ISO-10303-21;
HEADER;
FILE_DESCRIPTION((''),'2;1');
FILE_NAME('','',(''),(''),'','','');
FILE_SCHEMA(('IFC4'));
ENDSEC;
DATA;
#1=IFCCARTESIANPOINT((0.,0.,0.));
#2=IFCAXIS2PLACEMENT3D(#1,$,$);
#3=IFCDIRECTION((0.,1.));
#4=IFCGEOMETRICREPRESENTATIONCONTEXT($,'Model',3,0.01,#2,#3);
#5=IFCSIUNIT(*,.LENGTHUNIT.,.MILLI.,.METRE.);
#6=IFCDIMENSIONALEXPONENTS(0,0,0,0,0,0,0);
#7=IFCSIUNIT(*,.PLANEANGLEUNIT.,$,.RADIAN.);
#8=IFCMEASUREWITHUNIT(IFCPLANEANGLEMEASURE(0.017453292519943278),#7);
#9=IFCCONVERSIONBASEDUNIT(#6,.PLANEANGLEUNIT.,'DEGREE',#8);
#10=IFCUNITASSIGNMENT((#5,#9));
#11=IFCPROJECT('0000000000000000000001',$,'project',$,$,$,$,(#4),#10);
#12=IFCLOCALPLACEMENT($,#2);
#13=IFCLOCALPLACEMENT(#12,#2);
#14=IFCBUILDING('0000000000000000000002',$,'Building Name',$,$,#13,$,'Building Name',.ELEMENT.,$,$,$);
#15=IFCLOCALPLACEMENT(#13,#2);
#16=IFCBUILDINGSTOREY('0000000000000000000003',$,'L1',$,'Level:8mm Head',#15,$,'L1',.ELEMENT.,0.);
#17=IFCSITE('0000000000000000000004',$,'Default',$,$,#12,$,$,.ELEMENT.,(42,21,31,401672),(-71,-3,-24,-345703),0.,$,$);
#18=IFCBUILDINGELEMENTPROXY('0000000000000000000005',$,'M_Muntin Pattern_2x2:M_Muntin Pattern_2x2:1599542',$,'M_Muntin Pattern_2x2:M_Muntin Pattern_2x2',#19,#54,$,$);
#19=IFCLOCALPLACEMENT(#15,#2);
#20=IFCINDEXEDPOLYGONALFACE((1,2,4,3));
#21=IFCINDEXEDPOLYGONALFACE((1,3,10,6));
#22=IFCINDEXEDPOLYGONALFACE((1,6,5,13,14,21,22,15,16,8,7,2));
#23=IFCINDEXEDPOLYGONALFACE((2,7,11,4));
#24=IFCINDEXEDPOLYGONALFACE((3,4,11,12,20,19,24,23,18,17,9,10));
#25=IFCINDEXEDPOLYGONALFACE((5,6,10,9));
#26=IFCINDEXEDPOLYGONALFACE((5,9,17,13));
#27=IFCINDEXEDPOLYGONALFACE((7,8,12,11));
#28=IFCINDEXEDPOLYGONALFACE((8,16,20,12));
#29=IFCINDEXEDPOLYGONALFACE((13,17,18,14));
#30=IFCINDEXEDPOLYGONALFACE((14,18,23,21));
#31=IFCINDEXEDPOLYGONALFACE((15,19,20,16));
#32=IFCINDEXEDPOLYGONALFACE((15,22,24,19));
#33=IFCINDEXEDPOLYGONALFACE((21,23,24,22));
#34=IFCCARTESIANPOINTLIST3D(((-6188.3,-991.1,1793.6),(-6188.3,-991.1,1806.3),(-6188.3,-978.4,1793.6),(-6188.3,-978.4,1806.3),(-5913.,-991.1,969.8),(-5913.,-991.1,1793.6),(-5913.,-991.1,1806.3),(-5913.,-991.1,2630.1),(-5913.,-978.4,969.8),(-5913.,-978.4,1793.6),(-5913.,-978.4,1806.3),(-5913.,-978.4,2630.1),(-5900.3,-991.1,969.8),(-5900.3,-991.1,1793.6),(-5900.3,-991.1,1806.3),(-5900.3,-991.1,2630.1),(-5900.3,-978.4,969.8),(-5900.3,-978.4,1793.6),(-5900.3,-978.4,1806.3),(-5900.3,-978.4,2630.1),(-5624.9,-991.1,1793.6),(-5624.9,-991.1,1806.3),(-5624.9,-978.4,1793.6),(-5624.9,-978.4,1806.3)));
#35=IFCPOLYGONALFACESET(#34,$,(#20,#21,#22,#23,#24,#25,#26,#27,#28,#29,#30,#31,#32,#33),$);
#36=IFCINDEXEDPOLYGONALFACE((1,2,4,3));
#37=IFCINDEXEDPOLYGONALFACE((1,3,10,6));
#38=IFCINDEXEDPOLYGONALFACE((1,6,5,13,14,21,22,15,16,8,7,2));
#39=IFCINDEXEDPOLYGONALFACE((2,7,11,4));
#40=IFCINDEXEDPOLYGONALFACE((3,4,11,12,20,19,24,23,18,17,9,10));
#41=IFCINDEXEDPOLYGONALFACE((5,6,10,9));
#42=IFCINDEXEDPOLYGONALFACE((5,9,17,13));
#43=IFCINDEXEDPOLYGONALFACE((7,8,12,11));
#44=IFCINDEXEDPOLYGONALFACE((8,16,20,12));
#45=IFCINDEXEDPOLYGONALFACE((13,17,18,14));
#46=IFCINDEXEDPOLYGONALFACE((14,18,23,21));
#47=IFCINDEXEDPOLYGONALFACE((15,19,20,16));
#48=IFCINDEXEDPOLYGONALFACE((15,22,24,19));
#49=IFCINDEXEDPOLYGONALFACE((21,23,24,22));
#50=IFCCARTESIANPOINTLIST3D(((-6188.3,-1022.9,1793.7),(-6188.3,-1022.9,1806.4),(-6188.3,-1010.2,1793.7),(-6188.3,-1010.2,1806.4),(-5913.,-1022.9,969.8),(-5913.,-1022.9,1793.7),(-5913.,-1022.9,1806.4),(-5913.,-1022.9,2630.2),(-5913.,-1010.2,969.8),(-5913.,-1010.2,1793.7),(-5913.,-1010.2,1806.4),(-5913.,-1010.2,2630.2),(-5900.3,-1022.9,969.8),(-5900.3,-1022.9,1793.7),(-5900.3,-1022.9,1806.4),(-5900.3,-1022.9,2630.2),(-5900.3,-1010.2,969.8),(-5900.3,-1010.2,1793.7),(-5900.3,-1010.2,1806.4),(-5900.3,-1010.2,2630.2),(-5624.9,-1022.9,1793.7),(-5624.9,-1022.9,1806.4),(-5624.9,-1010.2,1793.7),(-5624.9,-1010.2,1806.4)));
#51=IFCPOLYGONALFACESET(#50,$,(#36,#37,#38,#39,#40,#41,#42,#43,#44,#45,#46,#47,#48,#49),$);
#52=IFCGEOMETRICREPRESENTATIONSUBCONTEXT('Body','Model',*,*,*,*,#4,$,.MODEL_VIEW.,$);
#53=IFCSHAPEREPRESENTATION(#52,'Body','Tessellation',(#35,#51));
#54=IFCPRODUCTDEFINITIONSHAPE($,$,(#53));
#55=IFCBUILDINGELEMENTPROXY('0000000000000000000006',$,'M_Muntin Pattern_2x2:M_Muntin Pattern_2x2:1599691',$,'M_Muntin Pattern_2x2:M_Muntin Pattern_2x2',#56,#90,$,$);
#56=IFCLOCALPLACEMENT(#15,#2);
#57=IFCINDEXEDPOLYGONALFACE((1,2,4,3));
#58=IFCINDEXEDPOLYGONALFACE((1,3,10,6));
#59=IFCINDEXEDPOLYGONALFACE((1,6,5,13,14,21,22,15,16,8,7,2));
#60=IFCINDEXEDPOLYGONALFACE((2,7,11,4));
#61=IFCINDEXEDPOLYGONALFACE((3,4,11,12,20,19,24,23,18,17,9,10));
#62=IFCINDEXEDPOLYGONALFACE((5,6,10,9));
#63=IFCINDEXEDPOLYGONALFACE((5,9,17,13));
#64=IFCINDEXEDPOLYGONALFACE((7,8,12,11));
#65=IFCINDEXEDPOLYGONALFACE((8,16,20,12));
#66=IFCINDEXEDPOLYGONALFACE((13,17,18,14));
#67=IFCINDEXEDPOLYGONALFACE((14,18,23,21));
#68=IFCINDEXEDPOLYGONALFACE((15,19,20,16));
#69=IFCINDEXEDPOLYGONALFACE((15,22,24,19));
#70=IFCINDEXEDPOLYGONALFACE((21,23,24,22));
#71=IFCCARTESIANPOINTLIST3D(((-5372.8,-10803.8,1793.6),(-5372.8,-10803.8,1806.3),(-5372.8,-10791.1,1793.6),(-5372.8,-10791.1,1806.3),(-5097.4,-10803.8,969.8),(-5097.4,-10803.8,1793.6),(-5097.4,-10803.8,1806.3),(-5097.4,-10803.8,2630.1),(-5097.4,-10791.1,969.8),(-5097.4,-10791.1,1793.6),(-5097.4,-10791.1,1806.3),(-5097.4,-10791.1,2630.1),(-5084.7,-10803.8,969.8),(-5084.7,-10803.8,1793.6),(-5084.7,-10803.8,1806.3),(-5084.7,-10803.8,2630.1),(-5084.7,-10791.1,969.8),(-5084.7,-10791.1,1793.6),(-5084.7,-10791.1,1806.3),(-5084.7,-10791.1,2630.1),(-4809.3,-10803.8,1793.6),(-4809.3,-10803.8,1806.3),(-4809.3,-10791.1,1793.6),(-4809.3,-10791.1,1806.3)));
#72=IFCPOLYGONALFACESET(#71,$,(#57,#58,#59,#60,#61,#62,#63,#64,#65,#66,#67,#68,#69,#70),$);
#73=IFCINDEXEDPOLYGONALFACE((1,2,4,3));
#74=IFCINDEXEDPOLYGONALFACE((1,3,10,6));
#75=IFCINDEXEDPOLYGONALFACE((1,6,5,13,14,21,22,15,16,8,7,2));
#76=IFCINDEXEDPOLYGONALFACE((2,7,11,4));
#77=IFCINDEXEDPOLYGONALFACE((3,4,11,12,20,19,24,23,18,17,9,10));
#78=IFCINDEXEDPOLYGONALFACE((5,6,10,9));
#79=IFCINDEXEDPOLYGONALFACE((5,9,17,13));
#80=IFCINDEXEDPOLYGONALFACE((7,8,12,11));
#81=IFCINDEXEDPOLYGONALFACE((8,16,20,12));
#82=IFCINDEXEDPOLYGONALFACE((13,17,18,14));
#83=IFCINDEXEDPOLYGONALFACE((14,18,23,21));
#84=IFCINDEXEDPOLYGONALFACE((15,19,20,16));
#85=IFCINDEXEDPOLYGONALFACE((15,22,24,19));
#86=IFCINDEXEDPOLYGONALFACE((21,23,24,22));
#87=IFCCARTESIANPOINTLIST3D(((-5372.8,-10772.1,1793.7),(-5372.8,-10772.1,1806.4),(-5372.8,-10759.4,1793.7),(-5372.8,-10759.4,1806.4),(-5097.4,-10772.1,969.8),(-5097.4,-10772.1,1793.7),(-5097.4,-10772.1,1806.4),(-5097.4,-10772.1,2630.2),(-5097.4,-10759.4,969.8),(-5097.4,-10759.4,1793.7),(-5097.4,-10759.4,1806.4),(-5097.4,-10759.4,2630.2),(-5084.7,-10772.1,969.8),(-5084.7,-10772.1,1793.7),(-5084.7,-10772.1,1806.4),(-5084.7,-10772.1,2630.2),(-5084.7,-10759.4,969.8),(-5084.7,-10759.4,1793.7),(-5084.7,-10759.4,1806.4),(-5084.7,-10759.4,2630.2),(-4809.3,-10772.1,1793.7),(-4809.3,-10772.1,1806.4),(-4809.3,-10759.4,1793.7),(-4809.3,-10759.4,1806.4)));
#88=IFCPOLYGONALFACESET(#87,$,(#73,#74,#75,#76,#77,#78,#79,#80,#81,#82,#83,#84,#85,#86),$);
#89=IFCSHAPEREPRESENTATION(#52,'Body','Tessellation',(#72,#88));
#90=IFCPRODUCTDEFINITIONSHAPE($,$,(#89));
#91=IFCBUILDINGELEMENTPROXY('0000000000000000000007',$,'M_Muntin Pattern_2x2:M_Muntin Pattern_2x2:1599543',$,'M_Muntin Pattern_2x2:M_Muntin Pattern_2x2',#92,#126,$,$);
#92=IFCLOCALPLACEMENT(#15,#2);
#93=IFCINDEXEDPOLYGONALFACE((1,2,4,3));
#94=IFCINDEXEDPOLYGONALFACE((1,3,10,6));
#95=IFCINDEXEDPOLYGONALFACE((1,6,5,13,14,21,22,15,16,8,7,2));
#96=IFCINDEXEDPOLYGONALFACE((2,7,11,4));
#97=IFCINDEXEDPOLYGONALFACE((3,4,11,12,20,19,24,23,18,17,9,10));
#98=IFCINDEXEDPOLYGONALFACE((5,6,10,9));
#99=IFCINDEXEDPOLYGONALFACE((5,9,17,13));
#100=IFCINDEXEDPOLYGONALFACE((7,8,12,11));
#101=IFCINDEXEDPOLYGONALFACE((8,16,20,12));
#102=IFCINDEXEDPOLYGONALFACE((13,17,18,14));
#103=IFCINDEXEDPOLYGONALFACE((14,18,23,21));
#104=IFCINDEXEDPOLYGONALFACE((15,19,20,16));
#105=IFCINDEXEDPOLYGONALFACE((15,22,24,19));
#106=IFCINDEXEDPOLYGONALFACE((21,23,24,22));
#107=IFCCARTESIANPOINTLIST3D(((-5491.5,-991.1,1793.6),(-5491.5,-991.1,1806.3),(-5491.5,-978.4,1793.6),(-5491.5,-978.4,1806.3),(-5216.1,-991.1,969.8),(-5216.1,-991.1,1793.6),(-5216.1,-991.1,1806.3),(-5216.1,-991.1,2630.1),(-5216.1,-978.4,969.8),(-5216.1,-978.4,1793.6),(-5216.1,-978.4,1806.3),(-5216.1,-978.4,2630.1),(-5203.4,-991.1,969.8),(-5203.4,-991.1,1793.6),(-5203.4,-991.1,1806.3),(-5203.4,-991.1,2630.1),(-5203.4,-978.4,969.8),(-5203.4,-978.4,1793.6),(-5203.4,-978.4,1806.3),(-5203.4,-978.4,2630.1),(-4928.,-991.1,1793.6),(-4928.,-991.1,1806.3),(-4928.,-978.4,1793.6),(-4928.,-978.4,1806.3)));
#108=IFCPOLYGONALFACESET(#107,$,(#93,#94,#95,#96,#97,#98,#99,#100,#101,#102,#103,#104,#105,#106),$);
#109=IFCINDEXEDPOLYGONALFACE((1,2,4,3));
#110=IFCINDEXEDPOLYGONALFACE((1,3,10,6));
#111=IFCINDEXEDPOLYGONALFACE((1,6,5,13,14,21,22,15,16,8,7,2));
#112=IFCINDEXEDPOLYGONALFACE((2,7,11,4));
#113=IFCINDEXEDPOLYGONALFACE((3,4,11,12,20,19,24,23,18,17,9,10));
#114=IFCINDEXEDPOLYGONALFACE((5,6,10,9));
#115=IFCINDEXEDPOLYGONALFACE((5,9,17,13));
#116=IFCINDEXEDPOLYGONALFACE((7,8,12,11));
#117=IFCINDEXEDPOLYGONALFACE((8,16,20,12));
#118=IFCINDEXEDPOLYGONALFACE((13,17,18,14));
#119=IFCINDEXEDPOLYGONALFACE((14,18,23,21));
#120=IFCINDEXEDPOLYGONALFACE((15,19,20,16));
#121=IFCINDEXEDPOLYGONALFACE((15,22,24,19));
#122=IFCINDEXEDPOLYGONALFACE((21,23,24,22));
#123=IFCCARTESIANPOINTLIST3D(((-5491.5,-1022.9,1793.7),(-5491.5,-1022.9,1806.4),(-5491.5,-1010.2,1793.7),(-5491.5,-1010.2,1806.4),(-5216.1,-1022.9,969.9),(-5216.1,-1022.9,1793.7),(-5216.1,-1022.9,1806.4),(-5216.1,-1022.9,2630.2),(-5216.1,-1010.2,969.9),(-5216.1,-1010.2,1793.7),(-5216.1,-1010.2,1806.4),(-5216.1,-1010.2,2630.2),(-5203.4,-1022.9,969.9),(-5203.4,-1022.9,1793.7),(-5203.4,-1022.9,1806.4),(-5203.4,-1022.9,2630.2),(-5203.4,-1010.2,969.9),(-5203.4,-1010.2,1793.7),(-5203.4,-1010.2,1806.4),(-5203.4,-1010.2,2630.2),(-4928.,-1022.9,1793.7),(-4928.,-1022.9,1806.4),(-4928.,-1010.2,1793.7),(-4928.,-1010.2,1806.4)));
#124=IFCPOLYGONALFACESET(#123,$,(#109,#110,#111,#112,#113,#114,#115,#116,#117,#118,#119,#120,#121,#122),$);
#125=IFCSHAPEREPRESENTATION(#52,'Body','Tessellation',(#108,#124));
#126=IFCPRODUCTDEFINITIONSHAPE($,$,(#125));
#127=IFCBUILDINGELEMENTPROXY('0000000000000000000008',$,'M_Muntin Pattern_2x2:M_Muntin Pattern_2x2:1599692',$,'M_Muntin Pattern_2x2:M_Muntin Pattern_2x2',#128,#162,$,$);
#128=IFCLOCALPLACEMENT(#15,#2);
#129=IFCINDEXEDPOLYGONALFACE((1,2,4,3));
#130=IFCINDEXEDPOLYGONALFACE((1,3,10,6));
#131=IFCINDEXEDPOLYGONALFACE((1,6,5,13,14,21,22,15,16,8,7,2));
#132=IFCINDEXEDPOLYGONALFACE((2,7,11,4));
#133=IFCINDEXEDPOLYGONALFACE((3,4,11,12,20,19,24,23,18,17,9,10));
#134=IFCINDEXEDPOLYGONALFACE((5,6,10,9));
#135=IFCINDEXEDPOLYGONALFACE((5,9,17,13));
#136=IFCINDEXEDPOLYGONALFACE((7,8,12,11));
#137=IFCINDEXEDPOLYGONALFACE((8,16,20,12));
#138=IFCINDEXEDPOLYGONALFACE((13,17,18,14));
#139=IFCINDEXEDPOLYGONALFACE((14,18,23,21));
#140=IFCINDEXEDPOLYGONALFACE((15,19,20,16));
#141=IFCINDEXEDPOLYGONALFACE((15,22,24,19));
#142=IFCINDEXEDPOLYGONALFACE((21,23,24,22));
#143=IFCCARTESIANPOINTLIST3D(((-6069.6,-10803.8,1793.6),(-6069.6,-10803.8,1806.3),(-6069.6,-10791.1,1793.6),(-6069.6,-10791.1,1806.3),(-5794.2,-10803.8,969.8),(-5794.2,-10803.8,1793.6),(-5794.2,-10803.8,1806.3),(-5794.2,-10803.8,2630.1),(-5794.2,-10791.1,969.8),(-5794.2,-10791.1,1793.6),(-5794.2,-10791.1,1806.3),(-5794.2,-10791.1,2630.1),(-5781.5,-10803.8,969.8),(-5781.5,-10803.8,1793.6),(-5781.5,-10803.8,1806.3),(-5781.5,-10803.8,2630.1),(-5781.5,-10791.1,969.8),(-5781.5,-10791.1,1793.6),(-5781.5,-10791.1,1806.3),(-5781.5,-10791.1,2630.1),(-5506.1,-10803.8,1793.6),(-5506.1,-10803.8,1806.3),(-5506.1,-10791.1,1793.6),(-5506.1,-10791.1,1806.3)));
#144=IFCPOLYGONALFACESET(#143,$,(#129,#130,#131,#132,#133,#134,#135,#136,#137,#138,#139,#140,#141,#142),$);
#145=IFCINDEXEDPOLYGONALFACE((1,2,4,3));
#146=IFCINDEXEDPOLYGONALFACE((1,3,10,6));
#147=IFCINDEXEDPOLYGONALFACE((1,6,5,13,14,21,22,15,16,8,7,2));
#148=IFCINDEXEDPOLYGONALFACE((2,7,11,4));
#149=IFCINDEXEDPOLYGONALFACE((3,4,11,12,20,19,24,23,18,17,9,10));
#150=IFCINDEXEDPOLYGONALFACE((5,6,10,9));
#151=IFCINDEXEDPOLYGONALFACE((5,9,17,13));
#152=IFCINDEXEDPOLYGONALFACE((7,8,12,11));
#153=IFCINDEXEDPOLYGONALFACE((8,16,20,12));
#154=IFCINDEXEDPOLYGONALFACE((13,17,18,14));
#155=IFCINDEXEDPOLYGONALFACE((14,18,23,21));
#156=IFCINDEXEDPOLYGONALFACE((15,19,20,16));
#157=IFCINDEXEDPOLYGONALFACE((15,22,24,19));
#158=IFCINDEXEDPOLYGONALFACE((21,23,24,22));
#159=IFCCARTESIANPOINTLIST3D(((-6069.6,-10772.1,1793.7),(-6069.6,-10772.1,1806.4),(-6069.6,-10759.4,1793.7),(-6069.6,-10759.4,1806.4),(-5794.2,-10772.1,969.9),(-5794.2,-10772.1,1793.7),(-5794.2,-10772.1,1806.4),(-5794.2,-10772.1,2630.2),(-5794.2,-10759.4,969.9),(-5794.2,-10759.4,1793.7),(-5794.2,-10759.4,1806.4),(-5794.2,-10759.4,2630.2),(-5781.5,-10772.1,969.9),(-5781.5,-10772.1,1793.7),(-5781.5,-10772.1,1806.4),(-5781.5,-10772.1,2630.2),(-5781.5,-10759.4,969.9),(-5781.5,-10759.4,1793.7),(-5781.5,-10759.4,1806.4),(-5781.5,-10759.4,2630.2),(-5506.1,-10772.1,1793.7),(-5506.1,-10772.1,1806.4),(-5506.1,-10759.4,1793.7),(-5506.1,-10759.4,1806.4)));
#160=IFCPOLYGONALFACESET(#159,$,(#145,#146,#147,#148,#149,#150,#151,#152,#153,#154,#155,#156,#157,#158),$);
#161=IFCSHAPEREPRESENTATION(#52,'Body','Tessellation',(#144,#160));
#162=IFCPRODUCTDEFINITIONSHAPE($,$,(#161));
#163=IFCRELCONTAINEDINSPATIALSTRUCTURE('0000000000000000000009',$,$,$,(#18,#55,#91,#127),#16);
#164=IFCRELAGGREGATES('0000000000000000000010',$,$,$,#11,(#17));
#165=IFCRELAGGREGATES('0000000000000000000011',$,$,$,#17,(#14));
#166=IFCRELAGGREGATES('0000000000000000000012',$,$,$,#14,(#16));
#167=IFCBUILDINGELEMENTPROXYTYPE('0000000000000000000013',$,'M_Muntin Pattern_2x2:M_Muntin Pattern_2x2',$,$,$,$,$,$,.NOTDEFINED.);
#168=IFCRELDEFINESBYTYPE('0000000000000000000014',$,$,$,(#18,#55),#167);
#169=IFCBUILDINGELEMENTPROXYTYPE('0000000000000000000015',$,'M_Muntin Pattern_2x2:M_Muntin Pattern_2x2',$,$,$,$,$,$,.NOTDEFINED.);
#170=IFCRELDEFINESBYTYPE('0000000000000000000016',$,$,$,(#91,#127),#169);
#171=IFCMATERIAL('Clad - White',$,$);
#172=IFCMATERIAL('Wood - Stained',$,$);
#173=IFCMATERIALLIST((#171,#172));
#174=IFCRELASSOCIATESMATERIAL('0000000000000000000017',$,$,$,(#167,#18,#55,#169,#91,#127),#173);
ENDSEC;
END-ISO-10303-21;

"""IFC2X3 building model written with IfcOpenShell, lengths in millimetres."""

from ifc_helpers import new_model, entity, si_unit, converted_unit, direction, frame, origin, place, context, subcontext, project, spatial, polyline, outline, extrude, source, transform, mapped, material, material_list, type_object, type_shapes, element, save


model = new_model("IFC2X3")

# Units and contexts
model_context = context("Model", 3, precision=0.01, world=origin(), true_north=direction((0.0, 1.0)))
body_context = subcontext(model_context, "Body", "Model", "MODEL_VIEW")
ifc_project = project(units=[si_unit("LENGTHUNIT", "METRE", prefix="MILLI"), converted_unit("PLANEANGLEUNIT", "DEGREE", entity("IfcPlaneAngleMeasure", 0.017453292519943278), si_unit("PLANEANGLEUNIT", "RADIAN"), dimensions=[0, 0, 0, 0, 0, 0, 0])], contexts=[model_context])

# Site, building, storey
site_placement = place(None, origin())
site = spatial("IfcSite", under=ifc_project, at=site_placement, Name="Default", CompositionType="ELEMENT", RefLatitude=(42, 21, 31, 401672), RefLongitude=(-71, -3, -24, -345703), RefElevation=0.0)
building_placement = place(site_placement, origin())
building = spatial("IfcBuilding", under=site, at=building_placement, Name="Building Name", LongName="Building Name", CompositionType="ELEMENT")
storey_placement = place(building_placement, origin())
storey = spatial("IfcBuildingStorey", under=building, at=storey_placement, Name="L1", ObjectType="Level:8mm Head", LongName="L1", CompositionType="ELEMENT", Elevation=0.0)

# Building element proxies
ifc_material_1 = material(Name="Clad - White")
ifc_material_2 = material(Name="Wood - Stained")
ifc_material_list = material_list([ifc_material_1, ifc_material_2])
building_element_proxy_type_1 = type_object("IfcBuildingElementProxyType", Name="M_Muntin Pattern_2x2:M_Muntin Pattern_2x2", PredefinedType="NOTDEFINED", material=ifc_material_list)
shared_shape_1 = source(origin(), body_context, "Body", "SweptSolid", [
    extrude(outline(polyline([(6.4, -6.4), (830.1, -6.4), (830.1, 6.3), (6.4, 6.3), (6.4, 281.7), (-6.3, 281.7), (-6.3, 6.3), (-830.2, 6.3), (-830.2, -6.4), (-6.3, -6.4), (-6.3, -281.7), (6.4, -281.7), (6.4, -6.4)])), frame((0.0, 9.5, 830.1), z_axis=(0.0, 1.0, 0.0), x_axis=(0.0, 0.0, 1.0)), (0.0, 0.0, 1.0), 12.7),
    extrude(outline(polyline([(6.4, -6.4), (830.2, -6.4), (830.2, 6.3), (6.4, 6.3), (6.4, 281.7), (-6.3, 281.7), (-6.3, 6.3), (-830.2, 6.3), (-830.2, -6.4), (-6.3, -6.4), (-6.3, -281.7), (6.4, -281.7), (6.4, -6.4)])), frame((0.0, -22.2, 830.2), z_axis=(0.0, 1.0, 0.0), x_axis=(0.0, 0.0, 1.0)), (0.0, 0.0, 1.0), 12.7),
])
type_shapes(building_element_proxy_type_1, [shared_shape_1])
proxy_1_placement = place(storey_placement, frame((-5906.6, -1000.6, 969.8)))
element("IfcBuildingElementProxy", 1, at=proxy_1_placement, inside=storey, type_object=building_element_proxy_type_1, material=ifc_material_list, Name="M_Muntin Pattern_2x2:M_Muntin Pattern_2x2:1599542", ObjectType="M_Muntin Pattern_2x2:M_Muntin Pattern_2x2", context=body_context, shape_type="MappedRepresentation", body=[
    mapped(shared_shape_1, transform((0.0, 0.0, 0.0), scale=1.0)),
])
proxy_2_placement = place(storey_placement, frame((-5091.0, -10781.6, 969.8), z_axis=(0.0, 0.0, 1.0), x_axis=(-1.0, 0.0, 0.0)))
element("IfcBuildingElementProxy", 2, at=proxy_2_placement, inside=storey, type_object=building_element_proxy_type_1, material=ifc_material_list, Name="M_Muntin Pattern_2x2:M_Muntin Pattern_2x2:1599691", ObjectType="M_Muntin Pattern_2x2:M_Muntin Pattern_2x2", context=body_context, shape_type="MappedRepresentation", body=[
    mapped(shared_shape_1, transform((0.0, 0.0, 0.0), scale=1.0)),
])
building_element_proxy_type_2 = type_object("IfcBuildingElementProxyType", Name="M_Muntin Pattern_2x2:M_Muntin Pattern_2x2", PredefinedType="NOTDEFINED", material=ifc_material_list)
shared_shape_2 = source(origin(), body_context, "Body", "SweptSolid", [
    extrude(outline(polyline([(6.4, -6.4), (830.1, -6.4), (830.1, 6.3), (6.4, 6.3), (6.4, 281.7), (-6.3, 281.7), (-6.3, 6.3), (-830.2, 6.3), (-830.2, -6.4), (-6.3, -6.4), (-6.3, -281.7), (6.4, -281.7), (6.4, -6.4)])), frame((0.0, -22.2, 830.1), z_axis=(0.0, 1.0, 0.0), x_axis=(0.0, 0.0, 1.0)), (0.0, 0.0, 1.0), 12.7),
    extrude(outline(polyline([(6.4, -6.4), (830.2, -6.4), (830.2, 6.3), (6.4, 6.3), (6.4, 281.7), (-6.3, 281.7), (-6.3, 6.3), (-830.2, 6.3), (-830.2, -6.4), (-6.3, -6.4), (-6.3, -281.7), (6.4, -281.7), (6.4, -6.4)])), frame((0.0, 9.5, 830.2), z_axis=(0.0, 1.0, 0.0), x_axis=(0.0, 0.0, 1.0)), (0.0, 0.0, 1.0), 12.7),
])
type_shapes(building_element_proxy_type_2, [shared_shape_2])
proxy_3_placement = place(storey_placement, frame((-5209.8, -1000.6, 969.9), z_axis=(0.0, 0.0, 1.0), x_axis=(-1.0, 0.0, 0.0)))
element("IfcBuildingElementProxy", 3, at=proxy_3_placement, inside=storey, type_object=building_element_proxy_type_2, material=ifc_material_list, Name="M_Muntin Pattern_2x2:M_Muntin Pattern_2x2:1599543", ObjectType="M_Muntin Pattern_2x2:M_Muntin Pattern_2x2", context=body_context, shape_type="MappedRepresentation", body=[
    mapped(shared_shape_2, transform((0.0, 0.0, 0.0), scale=1.0)),
])
proxy_4_placement = place(storey_placement, frame((-5787.9, -10781.6, 969.9)))
element("IfcBuildingElementProxy", 4, at=proxy_4_placement, inside=storey, type_object=building_element_proxy_type_2, material=ifc_material_list, Name="M_Muntin Pattern_2x2:M_Muntin Pattern_2x2:1599692", ObjectType="M_Muntin Pattern_2x2:M_Muntin Pattern_2x2", context=body_context, shape_type="MappedRepresentation", body=[
    mapped(shared_shape_2, transform((0.0, 0.0, 0.0), scale=1.0)),
])

save(model, "model.ifc")
